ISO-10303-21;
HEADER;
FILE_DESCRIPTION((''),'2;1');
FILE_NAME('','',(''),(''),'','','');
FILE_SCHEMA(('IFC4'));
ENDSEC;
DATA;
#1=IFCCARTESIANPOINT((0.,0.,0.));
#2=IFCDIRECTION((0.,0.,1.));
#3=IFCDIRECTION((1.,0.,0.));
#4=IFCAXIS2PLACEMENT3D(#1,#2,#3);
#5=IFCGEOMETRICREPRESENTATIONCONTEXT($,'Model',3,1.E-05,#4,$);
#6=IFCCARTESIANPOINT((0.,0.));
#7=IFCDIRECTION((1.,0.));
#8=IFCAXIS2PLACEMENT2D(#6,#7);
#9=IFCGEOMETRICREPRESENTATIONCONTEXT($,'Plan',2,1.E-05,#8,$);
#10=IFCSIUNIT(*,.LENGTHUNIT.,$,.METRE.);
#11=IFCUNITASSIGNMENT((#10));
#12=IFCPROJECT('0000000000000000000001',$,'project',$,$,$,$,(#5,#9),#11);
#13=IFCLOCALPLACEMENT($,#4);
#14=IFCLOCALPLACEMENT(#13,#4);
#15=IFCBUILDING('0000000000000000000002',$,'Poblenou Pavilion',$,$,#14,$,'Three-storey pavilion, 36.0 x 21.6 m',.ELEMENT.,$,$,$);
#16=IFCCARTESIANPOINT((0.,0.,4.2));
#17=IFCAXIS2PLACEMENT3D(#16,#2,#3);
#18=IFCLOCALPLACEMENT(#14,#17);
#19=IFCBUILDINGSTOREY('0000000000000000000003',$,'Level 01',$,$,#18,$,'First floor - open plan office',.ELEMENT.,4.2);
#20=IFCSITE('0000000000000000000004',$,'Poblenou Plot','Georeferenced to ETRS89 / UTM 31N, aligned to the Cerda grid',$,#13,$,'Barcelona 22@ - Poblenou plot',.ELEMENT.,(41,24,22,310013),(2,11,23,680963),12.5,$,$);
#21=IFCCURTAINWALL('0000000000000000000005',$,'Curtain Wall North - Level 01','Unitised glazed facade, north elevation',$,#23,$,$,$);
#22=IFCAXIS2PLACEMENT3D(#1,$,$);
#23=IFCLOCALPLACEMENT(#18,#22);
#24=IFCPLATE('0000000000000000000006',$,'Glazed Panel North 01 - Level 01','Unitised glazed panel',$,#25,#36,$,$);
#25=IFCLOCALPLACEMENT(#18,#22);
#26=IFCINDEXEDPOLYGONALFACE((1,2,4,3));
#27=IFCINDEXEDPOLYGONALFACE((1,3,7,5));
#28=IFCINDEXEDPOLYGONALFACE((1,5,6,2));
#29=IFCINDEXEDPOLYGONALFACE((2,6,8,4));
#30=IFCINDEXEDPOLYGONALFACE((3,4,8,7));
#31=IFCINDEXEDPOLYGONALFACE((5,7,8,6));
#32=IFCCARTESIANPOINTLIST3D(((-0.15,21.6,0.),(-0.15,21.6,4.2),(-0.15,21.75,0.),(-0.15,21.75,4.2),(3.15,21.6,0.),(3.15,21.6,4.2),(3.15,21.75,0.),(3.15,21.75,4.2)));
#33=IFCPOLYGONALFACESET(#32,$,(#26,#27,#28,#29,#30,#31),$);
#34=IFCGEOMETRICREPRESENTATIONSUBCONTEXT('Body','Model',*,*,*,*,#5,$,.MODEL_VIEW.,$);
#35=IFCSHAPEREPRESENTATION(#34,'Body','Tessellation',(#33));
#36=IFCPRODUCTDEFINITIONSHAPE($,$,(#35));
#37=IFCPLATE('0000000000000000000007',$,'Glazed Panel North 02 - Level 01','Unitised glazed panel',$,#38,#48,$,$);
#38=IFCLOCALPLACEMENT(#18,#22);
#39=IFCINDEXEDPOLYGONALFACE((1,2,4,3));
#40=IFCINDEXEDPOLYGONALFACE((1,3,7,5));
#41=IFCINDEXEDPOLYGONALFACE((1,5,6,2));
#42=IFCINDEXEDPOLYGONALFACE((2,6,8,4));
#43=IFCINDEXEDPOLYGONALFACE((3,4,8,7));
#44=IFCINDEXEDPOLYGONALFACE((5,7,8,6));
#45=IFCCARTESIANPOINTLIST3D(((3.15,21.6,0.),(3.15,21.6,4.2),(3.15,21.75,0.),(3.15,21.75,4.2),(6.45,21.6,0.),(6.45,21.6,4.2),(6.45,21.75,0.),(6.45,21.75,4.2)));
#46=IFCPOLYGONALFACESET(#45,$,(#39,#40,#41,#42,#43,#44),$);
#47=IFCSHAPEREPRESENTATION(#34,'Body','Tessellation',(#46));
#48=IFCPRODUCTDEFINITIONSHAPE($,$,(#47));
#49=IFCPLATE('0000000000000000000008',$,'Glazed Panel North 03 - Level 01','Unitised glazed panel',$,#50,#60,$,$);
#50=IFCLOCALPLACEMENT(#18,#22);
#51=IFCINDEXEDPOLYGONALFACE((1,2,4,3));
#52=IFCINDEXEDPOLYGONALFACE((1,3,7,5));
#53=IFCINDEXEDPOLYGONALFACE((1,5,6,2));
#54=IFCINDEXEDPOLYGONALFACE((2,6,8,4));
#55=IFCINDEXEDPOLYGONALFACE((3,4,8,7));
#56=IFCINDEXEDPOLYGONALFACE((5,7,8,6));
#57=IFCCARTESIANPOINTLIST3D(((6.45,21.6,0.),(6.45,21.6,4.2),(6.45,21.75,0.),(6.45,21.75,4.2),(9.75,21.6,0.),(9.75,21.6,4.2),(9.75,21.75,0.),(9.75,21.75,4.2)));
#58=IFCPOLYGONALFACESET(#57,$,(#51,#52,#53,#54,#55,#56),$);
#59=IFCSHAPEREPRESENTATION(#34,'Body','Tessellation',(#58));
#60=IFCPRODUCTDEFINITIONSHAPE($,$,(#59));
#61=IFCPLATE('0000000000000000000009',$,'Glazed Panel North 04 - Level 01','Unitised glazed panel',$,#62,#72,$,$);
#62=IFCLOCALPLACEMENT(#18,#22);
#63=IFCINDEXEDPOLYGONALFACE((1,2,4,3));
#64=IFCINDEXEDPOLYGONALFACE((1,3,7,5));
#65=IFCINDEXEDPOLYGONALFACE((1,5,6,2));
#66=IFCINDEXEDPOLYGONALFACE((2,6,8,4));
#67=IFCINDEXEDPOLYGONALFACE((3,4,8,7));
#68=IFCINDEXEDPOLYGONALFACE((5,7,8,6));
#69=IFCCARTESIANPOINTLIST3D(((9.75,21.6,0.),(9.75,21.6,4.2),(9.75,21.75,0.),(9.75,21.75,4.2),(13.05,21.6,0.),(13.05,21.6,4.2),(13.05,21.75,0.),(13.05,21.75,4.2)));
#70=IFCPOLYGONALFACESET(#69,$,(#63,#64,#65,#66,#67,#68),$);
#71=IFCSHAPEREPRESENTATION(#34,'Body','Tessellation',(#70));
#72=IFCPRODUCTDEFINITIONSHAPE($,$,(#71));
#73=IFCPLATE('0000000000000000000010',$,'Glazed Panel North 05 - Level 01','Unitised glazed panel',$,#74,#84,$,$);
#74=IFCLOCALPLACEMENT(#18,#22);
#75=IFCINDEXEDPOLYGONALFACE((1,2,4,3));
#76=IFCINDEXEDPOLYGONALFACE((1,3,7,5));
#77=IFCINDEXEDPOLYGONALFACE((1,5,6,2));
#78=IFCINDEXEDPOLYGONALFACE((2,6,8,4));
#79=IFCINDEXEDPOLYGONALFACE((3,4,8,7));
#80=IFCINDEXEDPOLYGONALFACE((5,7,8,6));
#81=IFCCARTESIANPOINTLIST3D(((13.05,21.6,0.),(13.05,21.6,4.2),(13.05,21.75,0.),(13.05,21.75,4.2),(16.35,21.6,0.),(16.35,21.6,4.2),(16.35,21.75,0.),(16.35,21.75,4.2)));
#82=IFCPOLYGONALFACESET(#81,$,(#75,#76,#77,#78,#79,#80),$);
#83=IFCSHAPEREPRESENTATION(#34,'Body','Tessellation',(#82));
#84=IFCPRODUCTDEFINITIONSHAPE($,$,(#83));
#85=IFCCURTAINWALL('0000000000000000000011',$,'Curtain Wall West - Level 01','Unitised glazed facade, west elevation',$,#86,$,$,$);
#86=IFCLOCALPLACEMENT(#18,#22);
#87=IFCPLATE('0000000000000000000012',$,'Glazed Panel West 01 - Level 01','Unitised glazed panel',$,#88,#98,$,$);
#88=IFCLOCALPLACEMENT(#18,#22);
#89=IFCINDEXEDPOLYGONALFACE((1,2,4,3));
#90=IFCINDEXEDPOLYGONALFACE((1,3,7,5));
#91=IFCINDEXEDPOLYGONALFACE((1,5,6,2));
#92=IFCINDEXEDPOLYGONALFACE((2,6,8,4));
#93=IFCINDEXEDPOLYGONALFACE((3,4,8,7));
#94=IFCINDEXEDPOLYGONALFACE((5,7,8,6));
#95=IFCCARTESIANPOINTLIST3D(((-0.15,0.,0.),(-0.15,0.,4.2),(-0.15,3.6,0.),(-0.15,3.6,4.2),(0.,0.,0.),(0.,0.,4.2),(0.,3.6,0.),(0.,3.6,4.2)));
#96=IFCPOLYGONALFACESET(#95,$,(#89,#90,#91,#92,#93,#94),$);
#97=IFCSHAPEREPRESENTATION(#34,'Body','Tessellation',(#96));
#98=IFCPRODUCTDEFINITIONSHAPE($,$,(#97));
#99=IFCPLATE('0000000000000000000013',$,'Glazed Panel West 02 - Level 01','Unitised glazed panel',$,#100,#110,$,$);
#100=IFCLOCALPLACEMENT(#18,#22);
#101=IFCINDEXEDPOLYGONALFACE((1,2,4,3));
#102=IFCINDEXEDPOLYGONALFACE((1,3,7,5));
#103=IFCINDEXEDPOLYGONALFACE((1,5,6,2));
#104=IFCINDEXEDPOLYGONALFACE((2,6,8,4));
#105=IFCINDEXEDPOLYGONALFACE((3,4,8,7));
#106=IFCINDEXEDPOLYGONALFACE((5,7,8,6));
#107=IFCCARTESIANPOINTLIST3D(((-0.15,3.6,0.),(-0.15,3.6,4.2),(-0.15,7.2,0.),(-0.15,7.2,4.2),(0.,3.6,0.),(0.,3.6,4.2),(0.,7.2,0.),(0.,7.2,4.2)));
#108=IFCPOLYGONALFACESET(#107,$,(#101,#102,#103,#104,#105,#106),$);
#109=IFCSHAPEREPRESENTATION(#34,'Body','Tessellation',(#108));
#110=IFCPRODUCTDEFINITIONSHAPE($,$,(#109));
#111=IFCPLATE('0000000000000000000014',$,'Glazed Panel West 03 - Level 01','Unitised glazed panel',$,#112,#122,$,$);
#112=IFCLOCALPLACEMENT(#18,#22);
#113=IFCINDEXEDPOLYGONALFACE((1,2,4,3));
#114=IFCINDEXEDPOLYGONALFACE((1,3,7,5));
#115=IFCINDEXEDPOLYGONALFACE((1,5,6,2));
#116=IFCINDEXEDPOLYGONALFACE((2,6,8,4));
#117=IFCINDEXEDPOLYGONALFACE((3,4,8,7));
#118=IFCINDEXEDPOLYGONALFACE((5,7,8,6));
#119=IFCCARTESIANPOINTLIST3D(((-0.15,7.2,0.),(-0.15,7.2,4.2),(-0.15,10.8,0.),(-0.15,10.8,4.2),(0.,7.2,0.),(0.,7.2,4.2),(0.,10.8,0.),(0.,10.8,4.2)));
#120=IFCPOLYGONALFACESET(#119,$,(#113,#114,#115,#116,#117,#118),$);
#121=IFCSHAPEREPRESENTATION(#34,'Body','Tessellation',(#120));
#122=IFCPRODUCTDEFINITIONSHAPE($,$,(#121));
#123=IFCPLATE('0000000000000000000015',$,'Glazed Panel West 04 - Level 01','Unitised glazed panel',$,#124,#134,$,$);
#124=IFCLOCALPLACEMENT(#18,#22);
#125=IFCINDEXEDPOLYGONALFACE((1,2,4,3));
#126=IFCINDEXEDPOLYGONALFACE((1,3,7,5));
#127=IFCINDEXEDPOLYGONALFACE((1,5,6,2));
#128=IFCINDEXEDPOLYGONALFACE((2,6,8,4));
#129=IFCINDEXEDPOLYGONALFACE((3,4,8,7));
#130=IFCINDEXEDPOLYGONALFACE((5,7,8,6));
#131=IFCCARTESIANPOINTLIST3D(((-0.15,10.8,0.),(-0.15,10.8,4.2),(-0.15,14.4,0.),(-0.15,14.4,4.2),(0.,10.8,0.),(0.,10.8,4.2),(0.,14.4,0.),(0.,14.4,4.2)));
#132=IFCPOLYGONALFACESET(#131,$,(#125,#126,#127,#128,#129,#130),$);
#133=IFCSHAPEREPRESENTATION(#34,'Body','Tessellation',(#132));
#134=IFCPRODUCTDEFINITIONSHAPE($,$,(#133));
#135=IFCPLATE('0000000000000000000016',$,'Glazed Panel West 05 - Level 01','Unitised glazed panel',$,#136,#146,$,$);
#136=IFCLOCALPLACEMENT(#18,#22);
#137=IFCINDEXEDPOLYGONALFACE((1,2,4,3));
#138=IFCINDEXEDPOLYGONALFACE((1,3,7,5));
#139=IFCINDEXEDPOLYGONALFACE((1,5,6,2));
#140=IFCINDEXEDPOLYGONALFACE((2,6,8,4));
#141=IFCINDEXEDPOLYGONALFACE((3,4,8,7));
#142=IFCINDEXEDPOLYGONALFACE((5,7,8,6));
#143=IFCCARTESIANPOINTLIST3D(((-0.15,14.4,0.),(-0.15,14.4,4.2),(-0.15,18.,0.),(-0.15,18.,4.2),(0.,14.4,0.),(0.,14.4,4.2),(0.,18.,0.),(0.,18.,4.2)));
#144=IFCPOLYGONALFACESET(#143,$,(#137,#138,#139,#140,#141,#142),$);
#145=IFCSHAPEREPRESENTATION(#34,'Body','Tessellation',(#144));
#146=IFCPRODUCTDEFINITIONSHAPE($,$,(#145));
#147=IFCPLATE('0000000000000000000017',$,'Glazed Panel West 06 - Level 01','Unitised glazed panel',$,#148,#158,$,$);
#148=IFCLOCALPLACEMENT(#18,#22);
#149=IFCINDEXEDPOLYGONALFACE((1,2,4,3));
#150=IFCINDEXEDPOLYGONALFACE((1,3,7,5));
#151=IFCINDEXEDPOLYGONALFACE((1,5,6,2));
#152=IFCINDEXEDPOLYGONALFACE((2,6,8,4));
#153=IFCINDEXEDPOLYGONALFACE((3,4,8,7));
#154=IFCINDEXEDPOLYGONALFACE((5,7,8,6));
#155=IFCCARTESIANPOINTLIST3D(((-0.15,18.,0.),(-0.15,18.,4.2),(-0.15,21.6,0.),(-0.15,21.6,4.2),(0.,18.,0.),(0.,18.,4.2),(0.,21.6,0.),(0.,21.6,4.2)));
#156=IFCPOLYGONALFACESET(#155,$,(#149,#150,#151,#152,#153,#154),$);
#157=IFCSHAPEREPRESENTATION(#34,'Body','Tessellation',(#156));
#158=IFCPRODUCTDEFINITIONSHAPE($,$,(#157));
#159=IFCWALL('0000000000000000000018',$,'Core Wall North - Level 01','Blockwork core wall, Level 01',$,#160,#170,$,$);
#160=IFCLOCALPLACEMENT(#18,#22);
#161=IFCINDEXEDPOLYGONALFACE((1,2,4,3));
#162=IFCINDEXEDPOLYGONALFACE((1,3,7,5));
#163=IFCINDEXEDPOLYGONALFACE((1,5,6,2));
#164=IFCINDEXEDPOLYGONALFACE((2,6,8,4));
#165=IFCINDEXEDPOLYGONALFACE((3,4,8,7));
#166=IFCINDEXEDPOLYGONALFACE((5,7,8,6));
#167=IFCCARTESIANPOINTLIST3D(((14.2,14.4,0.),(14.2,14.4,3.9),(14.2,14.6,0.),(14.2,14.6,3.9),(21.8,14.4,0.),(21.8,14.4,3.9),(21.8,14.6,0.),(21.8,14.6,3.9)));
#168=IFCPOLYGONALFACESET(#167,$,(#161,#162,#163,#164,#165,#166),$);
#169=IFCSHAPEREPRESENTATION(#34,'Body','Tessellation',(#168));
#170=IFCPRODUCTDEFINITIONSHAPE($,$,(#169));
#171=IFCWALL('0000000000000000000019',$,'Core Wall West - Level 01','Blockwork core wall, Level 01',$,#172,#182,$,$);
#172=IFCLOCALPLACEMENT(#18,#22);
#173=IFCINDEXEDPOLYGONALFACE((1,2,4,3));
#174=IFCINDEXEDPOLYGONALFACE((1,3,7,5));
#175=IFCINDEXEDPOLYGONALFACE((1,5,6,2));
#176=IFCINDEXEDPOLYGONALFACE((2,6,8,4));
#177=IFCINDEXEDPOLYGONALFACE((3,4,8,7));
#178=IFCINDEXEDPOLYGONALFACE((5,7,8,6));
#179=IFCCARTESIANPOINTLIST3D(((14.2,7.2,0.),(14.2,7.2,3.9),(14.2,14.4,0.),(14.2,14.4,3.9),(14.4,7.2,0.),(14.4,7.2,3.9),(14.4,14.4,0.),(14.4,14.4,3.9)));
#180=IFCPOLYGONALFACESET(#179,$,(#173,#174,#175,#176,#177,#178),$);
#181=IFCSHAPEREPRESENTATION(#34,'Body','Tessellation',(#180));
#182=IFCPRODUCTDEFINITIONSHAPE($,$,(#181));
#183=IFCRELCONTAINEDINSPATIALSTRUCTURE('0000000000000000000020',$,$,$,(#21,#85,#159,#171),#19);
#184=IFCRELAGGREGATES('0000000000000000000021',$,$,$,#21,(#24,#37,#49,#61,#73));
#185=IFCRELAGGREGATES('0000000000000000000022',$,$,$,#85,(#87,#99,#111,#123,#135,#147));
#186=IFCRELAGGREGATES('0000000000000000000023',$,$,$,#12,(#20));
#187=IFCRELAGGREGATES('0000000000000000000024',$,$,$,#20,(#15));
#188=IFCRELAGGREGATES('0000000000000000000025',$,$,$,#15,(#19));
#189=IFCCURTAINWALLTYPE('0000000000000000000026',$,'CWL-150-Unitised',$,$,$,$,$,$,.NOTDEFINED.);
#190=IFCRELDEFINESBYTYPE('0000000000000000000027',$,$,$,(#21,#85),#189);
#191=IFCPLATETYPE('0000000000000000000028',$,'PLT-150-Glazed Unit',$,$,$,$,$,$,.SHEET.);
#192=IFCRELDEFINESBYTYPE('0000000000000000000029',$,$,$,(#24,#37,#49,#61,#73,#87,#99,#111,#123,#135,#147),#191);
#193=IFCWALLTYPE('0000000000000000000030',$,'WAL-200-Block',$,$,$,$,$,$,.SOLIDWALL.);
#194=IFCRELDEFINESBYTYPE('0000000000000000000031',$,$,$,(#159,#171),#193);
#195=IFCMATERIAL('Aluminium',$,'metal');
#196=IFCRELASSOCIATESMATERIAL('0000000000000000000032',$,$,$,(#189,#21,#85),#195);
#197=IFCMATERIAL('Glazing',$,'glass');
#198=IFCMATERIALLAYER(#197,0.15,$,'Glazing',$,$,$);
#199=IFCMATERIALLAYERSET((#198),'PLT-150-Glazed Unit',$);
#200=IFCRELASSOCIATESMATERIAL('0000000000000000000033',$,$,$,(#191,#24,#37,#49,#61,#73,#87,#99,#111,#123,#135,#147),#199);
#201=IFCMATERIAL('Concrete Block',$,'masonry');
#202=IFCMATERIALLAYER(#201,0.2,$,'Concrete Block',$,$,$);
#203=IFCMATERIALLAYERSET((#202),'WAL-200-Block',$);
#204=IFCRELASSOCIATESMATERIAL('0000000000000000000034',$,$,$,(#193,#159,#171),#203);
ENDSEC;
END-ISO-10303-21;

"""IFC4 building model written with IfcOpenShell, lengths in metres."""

from ifc_helpers import new_model, si_unit, frame, origin_with_axes, origin_2d_with_axis, place, context, subcontext, project, spatial, line, indexed_curve, outline, extrude, material, layer, layer_set, layer_usage, type_object, element, aggregate, save


model = new_model("IFC4")

# Units and contexts
model_context = context("Model", 3, precision=1e-05, world=origin_with_axes())
plan_context = context("Plan", 2, precision=1e-05, world=origin_2d_with_axis())
body_context = subcontext(model_context, "Body", "Model", "MODEL_VIEW")
ifc_project = project(units=[si_unit("LENGTHUNIT", "METRE")], contexts=[model_context, plan_context])

# Site, building, storey
site_placement = place(None, origin_with_axes())
site = spatial("IfcSite", under=ifc_project, at=site_placement, Name="Poblenou Plot", Description="Georeferenced to ETRS89 / UTM 31N, aligned to the Cerda grid", LongName="Barcelona 22@ - Poblenou plot", CompositionType="ELEMENT", RefLatitude=(41, 24, 22, 310013), RefLongitude=(2, 11, 23, 680963), RefElevation=12.5)
building_placement = place(site_placement, origin_with_axes())
building = spatial("IfcBuilding", under=site, at=building_placement, Name="Poblenou Pavilion", LongName="Three-storey pavilion, 36.0 x 21.6 m", CompositionType="ELEMENT")
storey_placement = place(building_placement, frame((0.0, 0.0, 4.2), z_axis=(0.0, 0.0, 1.0), x_axis=(1.0, 0.0, 0.0)))
storey = spatial("IfcBuildingStorey", under=building, at=storey_placement, Name="Level 01", LongName="First floor - open plan office", CompositionType="ELEMENT", Elevation=4.2)

# Curtain walls, plates
ifc_material_1 = material(Name="Aluminium", Category="metal")
curtain_wall_type = type_object("IfcCurtainWallType", Name="CWL-150-Unitised", PredefinedType="NOTDEFINED", material=ifc_material_1)
ifc_material_2 = material(Name="Glazing", Category="glass")
ifc_layer_1 = layer(ifc_material_2, 0.15, Name="Glazing")
ifc_layer_set_1 = layer_set([ifc_layer_1], Name="PLT-150-Glazed Unit")
plate_type = type_object("IfcPlateType", Name="PLT-150-Glazed Unit", PredefinedType="SHEET", material=ifc_layer_set_1)
curtain_wall_1_placement = place(storey_placement, frame((-0.15, 21.6, 0.0), z_axis=(0.0, 0.0, 1.0), x_axis=(1.0, 0.0, 0.0)))
curtain_wall_1 = element("IfcCurtainWall", 1, at=curtain_wall_1_placement, inside=storey, type_object=curtain_wall_type, material=ifc_material_1, Name="Curtain Wall North - Level 01", Description="Unitised glazed facade, north elevation")
ifc_layer_usage_1 = layer_usage(ifc_layer_set_1, "AXIS2", "POSITIVE", 0.0)
plate_1_placement = place(curtain_wall_1_placement, origin_with_axes())
plate_1 = element("IfcPlate", 2, at=plate_1_placement, type_object=plate_type, material=ifc_layer_usage_1, Name="Glazed Panel North 01 - Level 01", Description="Unitised glazed panel", context=body_context, shape_type="SweptSolid", body=[
    extrude(outline(indexed_curve([(0.0, 0.0), (3.3, 0.0), (3.3, 0.15), (0.0, 0.15)], segments=[line(1, 2, 3, 4, 1)])), origin_with_axes(), (0.0, 0.0, 1.0), 4.2),
])
ifc_layer_usage_2 = layer_usage(ifc_layer_set_1, "AXIS2", "POSITIVE", 0.0)
plate_2_placement = place(curtain_wall_1_placement, frame((3.3, 0.0, 0.0), z_axis=(0.0, 0.0, 1.0), x_axis=(1.0, 0.0, 0.0)))
plate_2 = element("IfcPlate", 3, at=plate_2_placement, type_object=plate_type, material=ifc_layer_usage_2, Name="Glazed Panel North 02 - Level 01", Description="Unitised glazed panel", context=body_context, shape_type="SweptSolid", body=[
    extrude(outline(indexed_curve([(0.0, 0.0), (3.3, 0.0), (3.3, 0.15), (0.0, 0.15)], segments=[line(1, 2, 3, 4, 1)])), origin_with_axes(), (0.0, 0.0, 1.0), 4.2),
])
ifc_layer_usage_3 = layer_usage(ifc_layer_set_1, "AXIS2", "POSITIVE", 0.0)
plate_3_placement = place(curtain_wall_1_placement, frame((6.6, 0.0, 0.0), z_axis=(0.0, 0.0, 1.0), x_axis=(1.0, 0.0, 0.0)))
plate_3 = element("IfcPlate", 4, at=plate_3_placement, type_object=plate_type, material=ifc_layer_usage_3, Name="Glazed Panel North 03 - Level 01", Description="Unitised glazed panel", context=body_context, shape_type="SweptSolid", body=[
    extrude(outline(indexed_curve([(0.0, 0.0), (3.3, 0.0), (3.3, 0.15), (0.0, 0.15)], segments=[line(1, 2, 3, 4, 1)])), origin_with_axes(), (0.0, 0.0, 1.0), 4.2),
])
ifc_layer_usage_4 = layer_usage(ifc_layer_set_1, "AXIS2", "POSITIVE", 0.0)
plate_4_placement = place(curtain_wall_1_placement, frame((9.9, 0.0, 0.0), z_axis=(0.0, 0.0, 1.0), x_axis=(1.0, 0.0, 0.0)))
plate_4 = element("IfcPlate", 5, at=plate_4_placement, type_object=plate_type, material=ifc_layer_usage_4, Name="Glazed Panel North 04 - Level 01", Description="Unitised glazed panel", context=body_context, shape_type="SweptSolid", body=[
    extrude(outline(indexed_curve([(0.0, 0.0), (3.3, 0.0), (3.3, 0.15), (0.0, 0.15)], segments=[line(1, 2, 3, 4, 1)])), origin_with_axes(), (0.0, 0.0, 1.0), 4.2),
])
ifc_layer_usage_5 = layer_usage(ifc_layer_set_1, "AXIS2", "POSITIVE", 0.0)
plate_5_placement = place(curtain_wall_1_placement, frame((13.2, 0.0, 0.0), z_axis=(0.0, 0.0, 1.0), x_axis=(1.0, 0.0, 0.0)))
plate_5 = element("IfcPlate", 6, at=plate_5_placement, type_object=plate_type, material=ifc_layer_usage_5, Name="Glazed Panel North 05 - Level 01", Description="Unitised glazed panel", context=body_context, shape_type="SweptSolid", body=[
    extrude(outline(indexed_curve([(0.0, 0.0), (3.3, 0.0), (3.3, 0.15), (0.0, 0.15)], segments=[line(1, 2, 3, 4, 1)])), origin_with_axes(), (0.0, 0.0, 1.0), 4.2),
])
aggregate(curtain_wall_1, [plate_1, plate_2, plate_3, plate_4, plate_5])
curtain_wall_2_placement = place(storey_placement, frame((0.0, 0.0, 0.0), z_axis=(0.0, 0.0, 1.0), x_axis=(0.0, 1.0, 0.0)))
curtain_wall_2 = element("IfcCurtainWall", 7, at=curtain_wall_2_placement, inside=storey, type_object=curtain_wall_type, material=ifc_material_1, Name="Curtain Wall West - Level 01", Description="Unitised glazed facade, west elevation")
ifc_layer_usage_6 = layer_usage(ifc_layer_set_1, "AXIS2", "POSITIVE", 0.0)
plate_6_placement = place(curtain_wall_2_placement, origin_with_axes())
plate_6 = element("IfcPlate", 8, at=plate_6_placement, type_object=plate_type, material=ifc_layer_usage_6, Name="Glazed Panel West 01 - Level 01", Description="Unitised glazed panel", context=body_context, shape_type="SweptSolid", body=[
    extrude(outline(indexed_curve([(0.0, 0.0), (3.6, 0.0), (3.6, 0.15), (0.0, 0.15)], segments=[line(1, 2, 3, 4, 1)])), origin_with_axes(), (0.0, 0.0, 1.0), 4.2),
])
ifc_layer_usage_7 = layer_usage(ifc_layer_set_1, "AXIS2", "POSITIVE", 0.0)
plate_7_placement = place(curtain_wall_2_placement, frame((3.6, 0.0, 0.0), z_axis=(0.0, 0.0, 1.0), x_axis=(1.0, 0.0, 0.0)))
plate_7 = element("IfcPlate", 9, at=plate_7_placement, type_object=plate_type, material=ifc_layer_usage_7, Name="Glazed Panel West 02 - Level 01", Description="Unitised glazed panel", context=body_context, shape_type="SweptSolid", body=[
    extrude(outline(indexed_curve([(0.0, 0.0), (3.6, 0.0), (3.6, 0.15), (0.0, 0.15)], segments=[line(1, 2, 3, 4, 1)])), origin_with_axes(), (0.0, 0.0, 1.0), 4.2),
])
ifc_layer_usage_8 = layer_usage(ifc_layer_set_1, "AXIS2", "POSITIVE", 0.0)
plate_8_placement = place(curtain_wall_2_placement, frame((7.2, 0.0, 0.0), z_axis=(0.0, 0.0, 1.0), x_axis=(1.0, 0.0, 0.0)))
plate_8 = element("IfcPlate", 10, at=plate_8_placement, type_object=plate_type, material=ifc_layer_usage_8, Name="Glazed Panel West 03 - Level 01", Description="Unitised glazed panel", context=body_context, shape_type="SweptSolid", body=[
    extrude(outline(indexed_curve([(0.0, 0.0), (3.6, 0.0), (3.6, 0.15), (0.0, 0.15)], segments=[line(1, 2, 3, 4, 1)])), origin_with_axes(), (0.0, 0.0, 1.0), 4.2),
])
ifc_layer_usage_9 = layer_usage(ifc_layer_set_1, "AXIS2", "POSITIVE", 0.0)
plate_9_placement = place(curtain_wall_2_placement, frame((10.8, 0.0, 0.0), z_axis=(0.0, 0.0, 1.0), x_axis=(1.0, 0.0, 0.0)))
plate_9 = element("IfcPlate", 11, at=plate_9_placement, type_object=plate_type, material=ifc_layer_usage_9, Name="Glazed Panel West 04 - Level 01", Description="Unitised glazed panel", context=body_context, shape_type="SweptSolid", body=[
    extrude(outline(indexed_curve([(0.0, 0.0), (3.6, 0.0), (3.6, 0.15), (0.0, 0.15)], segments=[line(1, 2, 3, 4, 1)])), origin_with_axes(), (0.0, 0.0, 1.0), 4.2),
])
ifc_layer_usage_10 = layer_usage(ifc_layer_set_1, "AXIS2", "POSITIVE", 0.0)
plate_10_placement = place(curtain_wall_2_placement, frame((14.4, 0.0, 0.0), z_axis=(0.0, 0.0, 1.0), x_axis=(1.0, 0.0, 0.0)))
plate_10 = element("IfcPlate", 12, at=plate_10_placement, type_object=plate_type, material=ifc_layer_usage_10, Name="Glazed Panel West 05 - Level 01", Description="Unitised glazed panel", context=body_context, shape_type="SweptSolid", body=[
    extrude(outline(indexed_curve([(0.0, 0.0), (3.6, 0.0), (3.6, 0.15), (0.0, 0.15)], segments=[line(1, 2, 3, 4, 1)])), origin_with_axes(), (0.0, 0.0, 1.0), 4.2),
])
ifc_layer_usage_11 = layer_usage(ifc_layer_set_1, "AXIS2", "POSITIVE", 0.0)
plate_11_placement = place(curtain_wall_2_placement, frame((18.0, 0.0, 0.0), z_axis=(0.0, 0.0, 1.0), x_axis=(1.0, 0.0, 0.0)))
plate_11 = element("IfcPlate", 13, at=plate_11_placement, type_object=plate_type, material=ifc_layer_usage_11, Name="Glazed Panel West 06 - Level 01", Description="Unitised glazed panel", context=body_context, shape_type="SweptSolid", body=[
    extrude(outline(indexed_curve([(0.0, 0.0), (3.6, 0.0), (3.6, 0.15), (0.0, 0.15)], segments=[line(1, 2, 3, 4, 1)])), origin_with_axes(), (0.0, 0.0, 1.0), 4.2),
])
aggregate(curtain_wall_2, [plate_6, plate_7, plate_8, plate_9, plate_10, plate_11])

# Walls
ifc_material_3 = material(Name="Concrete Block", Category="masonry")
ifc_layer_2 = layer(ifc_material_3, 0.2, Name="Concrete Block")
ifc_layer_set_2 = layer_set([ifc_layer_2], Name="WAL-200-Block")
ifc_layer_usage_12 = layer_usage(ifc_layer_set_2, "AXIS2", "POSITIVE", 0.0)
wall_type = type_object("IfcWallType", Name="WAL-200-Block", PredefinedType="SOLIDWALL", material=ifc_layer_set_2)
wall_1_placement = place(storey_placement, frame((14.2, 14.4, 0.0), z_axis=(0.0, 0.0, 1.0), x_axis=(1.0, 0.0, 0.0)))
element("IfcWall", 14, at=wall_1_placement, inside=storey, type_object=wall_type, material=ifc_layer_usage_12, Name="Core Wall North - Level 01", Description="Blockwork core wall, Level 01", context=body_context, shape_type="SweptSolid", body=[
    extrude(outline(indexed_curve([(0.0, 0.0), (7.6, 0.0), (7.6, 0.2), (0.0, 0.2)], segments=[line(1, 2, 3, 4, 1)])), origin_with_axes(), (0.0, 0.0, 1.0), 3.9),
])
ifc_layer_usage_13 = layer_usage(ifc_layer_set_2, "AXIS2", "POSITIVE", 0.0)
wall_2_placement = place(storey_placement, frame((14.4, 7.2, 0.0), z_axis=(0.0, 0.0, 1.0), x_axis=(0.0, 1.0, 0.0)))
element("IfcWall", 15, at=wall_2_placement, inside=storey, type_object=wall_type, material=ifc_layer_usage_13, Name="Core Wall West - Level 01", Description="Blockwork core wall, Level 01", context=body_context, shape_type="SweptSolid", body=[
    extrude(outline(indexed_curve([(0.0, 0.0), (7.2, 0.0), (7.2, 0.2), (0.0, 0.2)], segments=[line(1, 2, 3, 4, 1)])), origin_with_axes(), (0.0, 0.0, 1.0), 3.9),
])

save(model, "model.ifc")
